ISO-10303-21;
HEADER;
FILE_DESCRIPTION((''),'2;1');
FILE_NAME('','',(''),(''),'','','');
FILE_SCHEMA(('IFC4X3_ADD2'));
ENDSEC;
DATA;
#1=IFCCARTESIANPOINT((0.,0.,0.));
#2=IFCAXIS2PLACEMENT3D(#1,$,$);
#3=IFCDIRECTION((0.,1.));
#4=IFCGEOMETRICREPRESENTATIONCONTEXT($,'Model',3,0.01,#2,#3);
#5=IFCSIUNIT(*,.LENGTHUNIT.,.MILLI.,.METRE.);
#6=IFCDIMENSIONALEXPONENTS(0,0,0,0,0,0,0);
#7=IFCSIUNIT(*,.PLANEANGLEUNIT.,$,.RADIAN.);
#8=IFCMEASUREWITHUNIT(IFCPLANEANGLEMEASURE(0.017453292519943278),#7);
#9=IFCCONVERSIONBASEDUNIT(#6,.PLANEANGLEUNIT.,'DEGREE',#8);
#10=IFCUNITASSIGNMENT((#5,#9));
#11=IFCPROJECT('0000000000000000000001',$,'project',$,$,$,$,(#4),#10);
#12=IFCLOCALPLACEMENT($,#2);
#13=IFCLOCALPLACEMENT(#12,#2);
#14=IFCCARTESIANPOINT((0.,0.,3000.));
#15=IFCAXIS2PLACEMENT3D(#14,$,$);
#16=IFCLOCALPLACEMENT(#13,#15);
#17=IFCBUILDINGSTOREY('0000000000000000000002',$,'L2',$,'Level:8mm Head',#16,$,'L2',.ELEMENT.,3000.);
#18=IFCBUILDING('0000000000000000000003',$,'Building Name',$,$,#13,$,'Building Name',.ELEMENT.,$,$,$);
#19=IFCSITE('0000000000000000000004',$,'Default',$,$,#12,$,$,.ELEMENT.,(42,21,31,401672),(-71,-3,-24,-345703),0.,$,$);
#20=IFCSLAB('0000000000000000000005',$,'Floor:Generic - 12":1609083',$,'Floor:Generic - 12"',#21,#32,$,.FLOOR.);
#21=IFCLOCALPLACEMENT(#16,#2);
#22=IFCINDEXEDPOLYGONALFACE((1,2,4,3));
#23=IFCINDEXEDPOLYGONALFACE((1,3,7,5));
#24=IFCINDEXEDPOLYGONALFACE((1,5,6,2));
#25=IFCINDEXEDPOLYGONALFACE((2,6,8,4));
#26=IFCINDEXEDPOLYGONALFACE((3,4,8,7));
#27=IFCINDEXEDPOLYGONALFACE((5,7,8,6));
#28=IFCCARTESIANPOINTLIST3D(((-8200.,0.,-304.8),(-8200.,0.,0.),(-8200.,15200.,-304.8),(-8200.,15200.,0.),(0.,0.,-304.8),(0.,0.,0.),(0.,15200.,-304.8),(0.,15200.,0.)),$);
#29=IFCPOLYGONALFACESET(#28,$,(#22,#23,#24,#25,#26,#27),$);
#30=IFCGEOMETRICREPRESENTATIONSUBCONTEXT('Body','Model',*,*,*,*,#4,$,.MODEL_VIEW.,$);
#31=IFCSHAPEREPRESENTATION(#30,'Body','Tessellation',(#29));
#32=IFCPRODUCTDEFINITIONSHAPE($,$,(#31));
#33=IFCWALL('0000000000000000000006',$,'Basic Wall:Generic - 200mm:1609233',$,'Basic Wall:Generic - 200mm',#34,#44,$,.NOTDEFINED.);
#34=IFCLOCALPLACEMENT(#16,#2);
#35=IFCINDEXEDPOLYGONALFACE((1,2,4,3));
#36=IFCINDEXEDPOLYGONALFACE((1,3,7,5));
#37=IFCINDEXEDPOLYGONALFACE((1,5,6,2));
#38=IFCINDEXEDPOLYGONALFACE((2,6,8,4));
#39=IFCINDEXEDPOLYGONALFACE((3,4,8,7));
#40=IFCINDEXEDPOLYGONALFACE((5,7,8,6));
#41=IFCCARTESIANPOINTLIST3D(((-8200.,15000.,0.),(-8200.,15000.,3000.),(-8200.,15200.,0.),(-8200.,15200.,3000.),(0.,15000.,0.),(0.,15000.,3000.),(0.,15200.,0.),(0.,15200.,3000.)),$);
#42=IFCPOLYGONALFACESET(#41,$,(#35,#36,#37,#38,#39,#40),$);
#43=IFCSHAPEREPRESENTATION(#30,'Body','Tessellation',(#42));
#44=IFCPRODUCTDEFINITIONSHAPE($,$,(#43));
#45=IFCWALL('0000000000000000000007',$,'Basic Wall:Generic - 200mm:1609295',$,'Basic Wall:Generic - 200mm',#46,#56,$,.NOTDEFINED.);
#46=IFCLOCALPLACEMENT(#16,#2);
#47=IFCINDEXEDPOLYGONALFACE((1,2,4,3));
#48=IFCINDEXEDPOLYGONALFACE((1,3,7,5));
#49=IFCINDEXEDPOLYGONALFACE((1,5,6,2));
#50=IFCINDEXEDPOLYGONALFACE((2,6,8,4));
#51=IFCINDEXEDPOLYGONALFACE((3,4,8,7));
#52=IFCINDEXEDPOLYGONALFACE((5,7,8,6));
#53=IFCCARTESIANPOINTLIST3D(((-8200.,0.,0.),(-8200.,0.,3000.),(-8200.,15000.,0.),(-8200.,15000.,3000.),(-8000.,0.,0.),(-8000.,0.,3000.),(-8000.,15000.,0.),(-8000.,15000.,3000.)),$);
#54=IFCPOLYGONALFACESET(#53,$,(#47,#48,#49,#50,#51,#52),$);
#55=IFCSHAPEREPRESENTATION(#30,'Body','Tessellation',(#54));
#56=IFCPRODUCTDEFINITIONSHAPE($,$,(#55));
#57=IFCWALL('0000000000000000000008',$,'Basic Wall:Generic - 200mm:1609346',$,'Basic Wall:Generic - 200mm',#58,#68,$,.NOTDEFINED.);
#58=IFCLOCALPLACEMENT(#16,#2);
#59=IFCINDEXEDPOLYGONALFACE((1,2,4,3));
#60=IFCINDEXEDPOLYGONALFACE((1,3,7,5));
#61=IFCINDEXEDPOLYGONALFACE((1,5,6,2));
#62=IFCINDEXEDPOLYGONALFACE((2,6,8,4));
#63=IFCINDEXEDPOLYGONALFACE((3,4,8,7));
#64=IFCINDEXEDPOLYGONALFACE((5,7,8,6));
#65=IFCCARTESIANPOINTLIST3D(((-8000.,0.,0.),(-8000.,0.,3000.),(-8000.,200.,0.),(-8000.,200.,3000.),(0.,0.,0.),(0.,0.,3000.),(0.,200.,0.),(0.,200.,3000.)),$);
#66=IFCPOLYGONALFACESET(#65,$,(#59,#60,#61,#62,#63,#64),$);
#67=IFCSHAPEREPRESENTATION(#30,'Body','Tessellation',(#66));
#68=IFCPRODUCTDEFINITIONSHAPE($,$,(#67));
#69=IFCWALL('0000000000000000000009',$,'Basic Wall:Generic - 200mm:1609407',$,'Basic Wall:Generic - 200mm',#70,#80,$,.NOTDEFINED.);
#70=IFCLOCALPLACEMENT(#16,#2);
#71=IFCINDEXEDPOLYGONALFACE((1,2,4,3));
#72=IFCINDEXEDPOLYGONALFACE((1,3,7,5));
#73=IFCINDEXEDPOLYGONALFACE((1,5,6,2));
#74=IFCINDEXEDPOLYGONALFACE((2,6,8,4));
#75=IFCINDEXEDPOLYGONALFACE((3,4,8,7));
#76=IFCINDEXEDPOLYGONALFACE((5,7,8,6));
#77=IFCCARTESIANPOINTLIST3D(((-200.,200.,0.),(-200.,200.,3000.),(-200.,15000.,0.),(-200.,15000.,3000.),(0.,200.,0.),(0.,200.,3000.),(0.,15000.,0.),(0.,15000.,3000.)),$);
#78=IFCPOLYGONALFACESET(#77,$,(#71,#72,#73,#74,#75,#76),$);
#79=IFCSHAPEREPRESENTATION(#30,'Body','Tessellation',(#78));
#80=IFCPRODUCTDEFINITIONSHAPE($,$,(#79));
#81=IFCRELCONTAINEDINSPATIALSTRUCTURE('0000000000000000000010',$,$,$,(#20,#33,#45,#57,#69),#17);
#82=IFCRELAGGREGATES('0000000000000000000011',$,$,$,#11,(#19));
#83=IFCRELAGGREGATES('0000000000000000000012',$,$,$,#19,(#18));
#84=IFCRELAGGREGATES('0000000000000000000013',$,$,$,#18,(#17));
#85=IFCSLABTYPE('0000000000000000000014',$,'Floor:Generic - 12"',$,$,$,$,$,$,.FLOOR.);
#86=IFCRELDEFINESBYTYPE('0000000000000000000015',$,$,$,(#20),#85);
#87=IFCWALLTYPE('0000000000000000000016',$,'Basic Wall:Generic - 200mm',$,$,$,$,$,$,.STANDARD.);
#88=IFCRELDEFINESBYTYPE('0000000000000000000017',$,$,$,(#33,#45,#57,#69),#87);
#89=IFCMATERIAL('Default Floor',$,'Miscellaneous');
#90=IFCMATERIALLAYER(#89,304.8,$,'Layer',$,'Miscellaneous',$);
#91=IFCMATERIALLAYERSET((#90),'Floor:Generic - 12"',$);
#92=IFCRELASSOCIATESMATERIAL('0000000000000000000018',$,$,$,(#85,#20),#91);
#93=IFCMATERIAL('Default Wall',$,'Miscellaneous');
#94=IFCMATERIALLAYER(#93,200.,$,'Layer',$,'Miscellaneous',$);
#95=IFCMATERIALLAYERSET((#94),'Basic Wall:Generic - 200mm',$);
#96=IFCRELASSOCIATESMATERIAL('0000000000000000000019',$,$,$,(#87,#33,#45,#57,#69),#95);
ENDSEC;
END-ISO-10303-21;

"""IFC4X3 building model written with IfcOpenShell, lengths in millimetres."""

from ifc_helpers import new_model, entity, si_unit, converted_unit, direction, frame, frame_2d, origin, place, context, subcontext, project, spatial, rectangle, extrude, material, layer, layer_set, layer_usage, type_object, element, save


model = new_model("IFC4X3")

# Units and contexts
model_context = context("Model", 3, precision=0.01, world=origin(), true_north=direction((0.0, 1.0)))
body_context = subcontext(model_context, "Body", "Model", "MODEL_VIEW")
ifc_project = project(units=[si_unit("LENGTHUNIT", "METRE", prefix="MILLI"), converted_unit("PLANEANGLEUNIT", "DEGREE", entity("IfcPlaneAngleMeasure", 0.017453292519943278), si_unit("PLANEANGLEUNIT", "RADIAN"), dimensions=[0, 0, 0, 0, 0, 0, 0])], contexts=[model_context])

# Site, building, storey
site_placement = place(None, origin())
site = spatial("IfcSite", under=ifc_project, at=site_placement, Name="Default", CompositionType="ELEMENT", RefLatitude=(42, 21, 31, 401672), RefLongitude=(-71, -3, -24, -345703), RefElevation=0.0)
building_placement = place(site_placement, origin())
building = spatial("IfcBuilding", under=site, at=building_placement, Name="Building Name", LongName="Building Name", CompositionType="ELEMENT")
storey_placement = place(building_placement, frame((0.0, 0.0, 3000.0)))
storey = spatial("IfcBuildingStorey", under=building, at=storey_placement, Name="L2", ObjectType="Level:8mm Head", LongName="L2", CompositionType="ELEMENT", Elevation=3000.0)

# Slab
ifc_material_1 = material(Name="Default Floor", Category="Miscellaneous")
ifc_layer_1 = layer(ifc_material_1, 304.8, Name="Layer", Category="Miscellaneous")
ifc_layer_set_1 = layer_set([ifc_layer_1], Name="Floor:Generic - 12\"")
ifc_layer_usage = layer_usage(ifc_layer_set_1, "AXIS3", "POSITIVE", 0.0)
slab_type = type_object("IfcSlabType", Name="Floor:Generic - 12\"", PredefinedType="FLOOR", material=ifc_layer_set_1)
slab_placement = place(storey_placement, origin())
element("IfcSlab", 1, at=slab_placement, inside=storey, type_object=slab_type, material=ifc_layer_usage, Name="Floor:Generic - 12\":1609083", ObjectType="Floor:Generic - 12\"", PredefinedType="FLOOR", context=body_context, shape_type="SweptSolid", body=[
    extrude(rectangle(XDim=15200.0, YDim=8200.0, at=frame_2d((0.0, 0.0), x_axis=(1.0, 0.0))), frame((-4100.0, 7600.0, 0.0), z_axis=(0.0, 0.0, -1.0), x_axis=(0.0, 1.0, 0.0)), (0.0, 0.0, 1.0), 304.8),
])

# Walls
ifc_material_2 = material(Name="Default Wall", Category="Miscellaneous")
ifc_layer_2 = layer(ifc_material_2, 200.0, Name="Layer", Category="Miscellaneous")
ifc_layer_set_2 = layer_set([ifc_layer_2], Name="Basic Wall:Generic - 200mm")
wall_type = type_object("IfcWallType", Name="Basic Wall:Generic - 200mm", PredefinedType="STANDARD", material=ifc_layer_set_2)
wall_1_placement = place(storey_placement, frame((0.0, 15100.0, 0.0), z_axis=(0.0, 0.0, 1.0), x_axis=(-1.0, 0.0, 0.0)))
element("IfcWall", 2, at=wall_1_placement, inside=storey, type_object=wall_type, material=ifc_layer_set_2, Name="Basic Wall:Generic - 200mm:1609233", ObjectType="Basic Wall:Generic - 200mm", PredefinedType="NOTDEFINED", context=body_context, shape_type="SweptSolid", body=[
    extrude(rectangle(XDim=8200.0, YDim=200.0, at=frame_2d((4100.0, 0.0), x_axis=(-1.0, 0.0))), origin(), (0.0, 0.0, 1.0), 3000.0),
])
wall_2_placement = place(storey_placement, frame((-8100.0, 15000.0, 0.0), z_axis=(0.0, 0.0, 1.0), x_axis=(0.0, -1.0, 0.0)))
element("IfcWall", 3, at=wall_2_placement, inside=storey, type_object=wall_type, material=ifc_layer_set_2, Name="Basic Wall:Generic - 200mm:1609295", ObjectType="Basic Wall:Generic - 200mm", PredefinedType="NOTDEFINED", context=body_context, shape_type="SweptSolid", body=[
    extrude(rectangle(XDim=15000.0, YDim=200.0, at=frame_2d((7500.0, 0.0), x_axis=(-1.0, 0.0))), origin(), (0.0, 0.0, 1.0), 3000.0),
])
wall_3_placement = place(storey_placement, frame((-8000.0, 100.0, 0.0)))
element("IfcWall", 4, at=wall_3_placement, inside=storey, type_object=wall_type, material=ifc_layer_set_2, Name="Basic Wall:Generic - 200mm:1609346", ObjectType="Basic Wall:Generic - 200mm", PredefinedType="NOTDEFINED", context=body_context, shape_type="SweptSolid", body=[
    extrude(rectangle(XDim=8000.0, YDim=200.0, at=frame_2d((4000.0, 0.0), x_axis=(-1.0, 0.0))), origin(), (0.0, 0.0, 1.0), 3000.0),
])
wall_4_placement = place(storey_placement, frame((-100.0, 200.0, 0.0), z_axis=(0.0, 0.0, 1.0), x_axis=(0.0, 1.0, 0.0)))
element("IfcWall", 5, at=wall_4_placement, inside=storey, type_object=wall_type, material=ifc_layer_set_2, Name="Basic Wall:Generic - 200mm:1609407", ObjectType="Basic Wall:Generic - 200mm", PredefinedType="NOTDEFINED", context=body_context, shape_type="SweptSolid", body=[
    extrude(rectangle(XDim=14800.0, YDim=200.0, at=frame_2d((7400.0, 0.0), x_axis=(-1.0, 0.0))), origin(), (0.0, 0.0, 1.0), 3000.0),
])

save(model, "model.ifc")
